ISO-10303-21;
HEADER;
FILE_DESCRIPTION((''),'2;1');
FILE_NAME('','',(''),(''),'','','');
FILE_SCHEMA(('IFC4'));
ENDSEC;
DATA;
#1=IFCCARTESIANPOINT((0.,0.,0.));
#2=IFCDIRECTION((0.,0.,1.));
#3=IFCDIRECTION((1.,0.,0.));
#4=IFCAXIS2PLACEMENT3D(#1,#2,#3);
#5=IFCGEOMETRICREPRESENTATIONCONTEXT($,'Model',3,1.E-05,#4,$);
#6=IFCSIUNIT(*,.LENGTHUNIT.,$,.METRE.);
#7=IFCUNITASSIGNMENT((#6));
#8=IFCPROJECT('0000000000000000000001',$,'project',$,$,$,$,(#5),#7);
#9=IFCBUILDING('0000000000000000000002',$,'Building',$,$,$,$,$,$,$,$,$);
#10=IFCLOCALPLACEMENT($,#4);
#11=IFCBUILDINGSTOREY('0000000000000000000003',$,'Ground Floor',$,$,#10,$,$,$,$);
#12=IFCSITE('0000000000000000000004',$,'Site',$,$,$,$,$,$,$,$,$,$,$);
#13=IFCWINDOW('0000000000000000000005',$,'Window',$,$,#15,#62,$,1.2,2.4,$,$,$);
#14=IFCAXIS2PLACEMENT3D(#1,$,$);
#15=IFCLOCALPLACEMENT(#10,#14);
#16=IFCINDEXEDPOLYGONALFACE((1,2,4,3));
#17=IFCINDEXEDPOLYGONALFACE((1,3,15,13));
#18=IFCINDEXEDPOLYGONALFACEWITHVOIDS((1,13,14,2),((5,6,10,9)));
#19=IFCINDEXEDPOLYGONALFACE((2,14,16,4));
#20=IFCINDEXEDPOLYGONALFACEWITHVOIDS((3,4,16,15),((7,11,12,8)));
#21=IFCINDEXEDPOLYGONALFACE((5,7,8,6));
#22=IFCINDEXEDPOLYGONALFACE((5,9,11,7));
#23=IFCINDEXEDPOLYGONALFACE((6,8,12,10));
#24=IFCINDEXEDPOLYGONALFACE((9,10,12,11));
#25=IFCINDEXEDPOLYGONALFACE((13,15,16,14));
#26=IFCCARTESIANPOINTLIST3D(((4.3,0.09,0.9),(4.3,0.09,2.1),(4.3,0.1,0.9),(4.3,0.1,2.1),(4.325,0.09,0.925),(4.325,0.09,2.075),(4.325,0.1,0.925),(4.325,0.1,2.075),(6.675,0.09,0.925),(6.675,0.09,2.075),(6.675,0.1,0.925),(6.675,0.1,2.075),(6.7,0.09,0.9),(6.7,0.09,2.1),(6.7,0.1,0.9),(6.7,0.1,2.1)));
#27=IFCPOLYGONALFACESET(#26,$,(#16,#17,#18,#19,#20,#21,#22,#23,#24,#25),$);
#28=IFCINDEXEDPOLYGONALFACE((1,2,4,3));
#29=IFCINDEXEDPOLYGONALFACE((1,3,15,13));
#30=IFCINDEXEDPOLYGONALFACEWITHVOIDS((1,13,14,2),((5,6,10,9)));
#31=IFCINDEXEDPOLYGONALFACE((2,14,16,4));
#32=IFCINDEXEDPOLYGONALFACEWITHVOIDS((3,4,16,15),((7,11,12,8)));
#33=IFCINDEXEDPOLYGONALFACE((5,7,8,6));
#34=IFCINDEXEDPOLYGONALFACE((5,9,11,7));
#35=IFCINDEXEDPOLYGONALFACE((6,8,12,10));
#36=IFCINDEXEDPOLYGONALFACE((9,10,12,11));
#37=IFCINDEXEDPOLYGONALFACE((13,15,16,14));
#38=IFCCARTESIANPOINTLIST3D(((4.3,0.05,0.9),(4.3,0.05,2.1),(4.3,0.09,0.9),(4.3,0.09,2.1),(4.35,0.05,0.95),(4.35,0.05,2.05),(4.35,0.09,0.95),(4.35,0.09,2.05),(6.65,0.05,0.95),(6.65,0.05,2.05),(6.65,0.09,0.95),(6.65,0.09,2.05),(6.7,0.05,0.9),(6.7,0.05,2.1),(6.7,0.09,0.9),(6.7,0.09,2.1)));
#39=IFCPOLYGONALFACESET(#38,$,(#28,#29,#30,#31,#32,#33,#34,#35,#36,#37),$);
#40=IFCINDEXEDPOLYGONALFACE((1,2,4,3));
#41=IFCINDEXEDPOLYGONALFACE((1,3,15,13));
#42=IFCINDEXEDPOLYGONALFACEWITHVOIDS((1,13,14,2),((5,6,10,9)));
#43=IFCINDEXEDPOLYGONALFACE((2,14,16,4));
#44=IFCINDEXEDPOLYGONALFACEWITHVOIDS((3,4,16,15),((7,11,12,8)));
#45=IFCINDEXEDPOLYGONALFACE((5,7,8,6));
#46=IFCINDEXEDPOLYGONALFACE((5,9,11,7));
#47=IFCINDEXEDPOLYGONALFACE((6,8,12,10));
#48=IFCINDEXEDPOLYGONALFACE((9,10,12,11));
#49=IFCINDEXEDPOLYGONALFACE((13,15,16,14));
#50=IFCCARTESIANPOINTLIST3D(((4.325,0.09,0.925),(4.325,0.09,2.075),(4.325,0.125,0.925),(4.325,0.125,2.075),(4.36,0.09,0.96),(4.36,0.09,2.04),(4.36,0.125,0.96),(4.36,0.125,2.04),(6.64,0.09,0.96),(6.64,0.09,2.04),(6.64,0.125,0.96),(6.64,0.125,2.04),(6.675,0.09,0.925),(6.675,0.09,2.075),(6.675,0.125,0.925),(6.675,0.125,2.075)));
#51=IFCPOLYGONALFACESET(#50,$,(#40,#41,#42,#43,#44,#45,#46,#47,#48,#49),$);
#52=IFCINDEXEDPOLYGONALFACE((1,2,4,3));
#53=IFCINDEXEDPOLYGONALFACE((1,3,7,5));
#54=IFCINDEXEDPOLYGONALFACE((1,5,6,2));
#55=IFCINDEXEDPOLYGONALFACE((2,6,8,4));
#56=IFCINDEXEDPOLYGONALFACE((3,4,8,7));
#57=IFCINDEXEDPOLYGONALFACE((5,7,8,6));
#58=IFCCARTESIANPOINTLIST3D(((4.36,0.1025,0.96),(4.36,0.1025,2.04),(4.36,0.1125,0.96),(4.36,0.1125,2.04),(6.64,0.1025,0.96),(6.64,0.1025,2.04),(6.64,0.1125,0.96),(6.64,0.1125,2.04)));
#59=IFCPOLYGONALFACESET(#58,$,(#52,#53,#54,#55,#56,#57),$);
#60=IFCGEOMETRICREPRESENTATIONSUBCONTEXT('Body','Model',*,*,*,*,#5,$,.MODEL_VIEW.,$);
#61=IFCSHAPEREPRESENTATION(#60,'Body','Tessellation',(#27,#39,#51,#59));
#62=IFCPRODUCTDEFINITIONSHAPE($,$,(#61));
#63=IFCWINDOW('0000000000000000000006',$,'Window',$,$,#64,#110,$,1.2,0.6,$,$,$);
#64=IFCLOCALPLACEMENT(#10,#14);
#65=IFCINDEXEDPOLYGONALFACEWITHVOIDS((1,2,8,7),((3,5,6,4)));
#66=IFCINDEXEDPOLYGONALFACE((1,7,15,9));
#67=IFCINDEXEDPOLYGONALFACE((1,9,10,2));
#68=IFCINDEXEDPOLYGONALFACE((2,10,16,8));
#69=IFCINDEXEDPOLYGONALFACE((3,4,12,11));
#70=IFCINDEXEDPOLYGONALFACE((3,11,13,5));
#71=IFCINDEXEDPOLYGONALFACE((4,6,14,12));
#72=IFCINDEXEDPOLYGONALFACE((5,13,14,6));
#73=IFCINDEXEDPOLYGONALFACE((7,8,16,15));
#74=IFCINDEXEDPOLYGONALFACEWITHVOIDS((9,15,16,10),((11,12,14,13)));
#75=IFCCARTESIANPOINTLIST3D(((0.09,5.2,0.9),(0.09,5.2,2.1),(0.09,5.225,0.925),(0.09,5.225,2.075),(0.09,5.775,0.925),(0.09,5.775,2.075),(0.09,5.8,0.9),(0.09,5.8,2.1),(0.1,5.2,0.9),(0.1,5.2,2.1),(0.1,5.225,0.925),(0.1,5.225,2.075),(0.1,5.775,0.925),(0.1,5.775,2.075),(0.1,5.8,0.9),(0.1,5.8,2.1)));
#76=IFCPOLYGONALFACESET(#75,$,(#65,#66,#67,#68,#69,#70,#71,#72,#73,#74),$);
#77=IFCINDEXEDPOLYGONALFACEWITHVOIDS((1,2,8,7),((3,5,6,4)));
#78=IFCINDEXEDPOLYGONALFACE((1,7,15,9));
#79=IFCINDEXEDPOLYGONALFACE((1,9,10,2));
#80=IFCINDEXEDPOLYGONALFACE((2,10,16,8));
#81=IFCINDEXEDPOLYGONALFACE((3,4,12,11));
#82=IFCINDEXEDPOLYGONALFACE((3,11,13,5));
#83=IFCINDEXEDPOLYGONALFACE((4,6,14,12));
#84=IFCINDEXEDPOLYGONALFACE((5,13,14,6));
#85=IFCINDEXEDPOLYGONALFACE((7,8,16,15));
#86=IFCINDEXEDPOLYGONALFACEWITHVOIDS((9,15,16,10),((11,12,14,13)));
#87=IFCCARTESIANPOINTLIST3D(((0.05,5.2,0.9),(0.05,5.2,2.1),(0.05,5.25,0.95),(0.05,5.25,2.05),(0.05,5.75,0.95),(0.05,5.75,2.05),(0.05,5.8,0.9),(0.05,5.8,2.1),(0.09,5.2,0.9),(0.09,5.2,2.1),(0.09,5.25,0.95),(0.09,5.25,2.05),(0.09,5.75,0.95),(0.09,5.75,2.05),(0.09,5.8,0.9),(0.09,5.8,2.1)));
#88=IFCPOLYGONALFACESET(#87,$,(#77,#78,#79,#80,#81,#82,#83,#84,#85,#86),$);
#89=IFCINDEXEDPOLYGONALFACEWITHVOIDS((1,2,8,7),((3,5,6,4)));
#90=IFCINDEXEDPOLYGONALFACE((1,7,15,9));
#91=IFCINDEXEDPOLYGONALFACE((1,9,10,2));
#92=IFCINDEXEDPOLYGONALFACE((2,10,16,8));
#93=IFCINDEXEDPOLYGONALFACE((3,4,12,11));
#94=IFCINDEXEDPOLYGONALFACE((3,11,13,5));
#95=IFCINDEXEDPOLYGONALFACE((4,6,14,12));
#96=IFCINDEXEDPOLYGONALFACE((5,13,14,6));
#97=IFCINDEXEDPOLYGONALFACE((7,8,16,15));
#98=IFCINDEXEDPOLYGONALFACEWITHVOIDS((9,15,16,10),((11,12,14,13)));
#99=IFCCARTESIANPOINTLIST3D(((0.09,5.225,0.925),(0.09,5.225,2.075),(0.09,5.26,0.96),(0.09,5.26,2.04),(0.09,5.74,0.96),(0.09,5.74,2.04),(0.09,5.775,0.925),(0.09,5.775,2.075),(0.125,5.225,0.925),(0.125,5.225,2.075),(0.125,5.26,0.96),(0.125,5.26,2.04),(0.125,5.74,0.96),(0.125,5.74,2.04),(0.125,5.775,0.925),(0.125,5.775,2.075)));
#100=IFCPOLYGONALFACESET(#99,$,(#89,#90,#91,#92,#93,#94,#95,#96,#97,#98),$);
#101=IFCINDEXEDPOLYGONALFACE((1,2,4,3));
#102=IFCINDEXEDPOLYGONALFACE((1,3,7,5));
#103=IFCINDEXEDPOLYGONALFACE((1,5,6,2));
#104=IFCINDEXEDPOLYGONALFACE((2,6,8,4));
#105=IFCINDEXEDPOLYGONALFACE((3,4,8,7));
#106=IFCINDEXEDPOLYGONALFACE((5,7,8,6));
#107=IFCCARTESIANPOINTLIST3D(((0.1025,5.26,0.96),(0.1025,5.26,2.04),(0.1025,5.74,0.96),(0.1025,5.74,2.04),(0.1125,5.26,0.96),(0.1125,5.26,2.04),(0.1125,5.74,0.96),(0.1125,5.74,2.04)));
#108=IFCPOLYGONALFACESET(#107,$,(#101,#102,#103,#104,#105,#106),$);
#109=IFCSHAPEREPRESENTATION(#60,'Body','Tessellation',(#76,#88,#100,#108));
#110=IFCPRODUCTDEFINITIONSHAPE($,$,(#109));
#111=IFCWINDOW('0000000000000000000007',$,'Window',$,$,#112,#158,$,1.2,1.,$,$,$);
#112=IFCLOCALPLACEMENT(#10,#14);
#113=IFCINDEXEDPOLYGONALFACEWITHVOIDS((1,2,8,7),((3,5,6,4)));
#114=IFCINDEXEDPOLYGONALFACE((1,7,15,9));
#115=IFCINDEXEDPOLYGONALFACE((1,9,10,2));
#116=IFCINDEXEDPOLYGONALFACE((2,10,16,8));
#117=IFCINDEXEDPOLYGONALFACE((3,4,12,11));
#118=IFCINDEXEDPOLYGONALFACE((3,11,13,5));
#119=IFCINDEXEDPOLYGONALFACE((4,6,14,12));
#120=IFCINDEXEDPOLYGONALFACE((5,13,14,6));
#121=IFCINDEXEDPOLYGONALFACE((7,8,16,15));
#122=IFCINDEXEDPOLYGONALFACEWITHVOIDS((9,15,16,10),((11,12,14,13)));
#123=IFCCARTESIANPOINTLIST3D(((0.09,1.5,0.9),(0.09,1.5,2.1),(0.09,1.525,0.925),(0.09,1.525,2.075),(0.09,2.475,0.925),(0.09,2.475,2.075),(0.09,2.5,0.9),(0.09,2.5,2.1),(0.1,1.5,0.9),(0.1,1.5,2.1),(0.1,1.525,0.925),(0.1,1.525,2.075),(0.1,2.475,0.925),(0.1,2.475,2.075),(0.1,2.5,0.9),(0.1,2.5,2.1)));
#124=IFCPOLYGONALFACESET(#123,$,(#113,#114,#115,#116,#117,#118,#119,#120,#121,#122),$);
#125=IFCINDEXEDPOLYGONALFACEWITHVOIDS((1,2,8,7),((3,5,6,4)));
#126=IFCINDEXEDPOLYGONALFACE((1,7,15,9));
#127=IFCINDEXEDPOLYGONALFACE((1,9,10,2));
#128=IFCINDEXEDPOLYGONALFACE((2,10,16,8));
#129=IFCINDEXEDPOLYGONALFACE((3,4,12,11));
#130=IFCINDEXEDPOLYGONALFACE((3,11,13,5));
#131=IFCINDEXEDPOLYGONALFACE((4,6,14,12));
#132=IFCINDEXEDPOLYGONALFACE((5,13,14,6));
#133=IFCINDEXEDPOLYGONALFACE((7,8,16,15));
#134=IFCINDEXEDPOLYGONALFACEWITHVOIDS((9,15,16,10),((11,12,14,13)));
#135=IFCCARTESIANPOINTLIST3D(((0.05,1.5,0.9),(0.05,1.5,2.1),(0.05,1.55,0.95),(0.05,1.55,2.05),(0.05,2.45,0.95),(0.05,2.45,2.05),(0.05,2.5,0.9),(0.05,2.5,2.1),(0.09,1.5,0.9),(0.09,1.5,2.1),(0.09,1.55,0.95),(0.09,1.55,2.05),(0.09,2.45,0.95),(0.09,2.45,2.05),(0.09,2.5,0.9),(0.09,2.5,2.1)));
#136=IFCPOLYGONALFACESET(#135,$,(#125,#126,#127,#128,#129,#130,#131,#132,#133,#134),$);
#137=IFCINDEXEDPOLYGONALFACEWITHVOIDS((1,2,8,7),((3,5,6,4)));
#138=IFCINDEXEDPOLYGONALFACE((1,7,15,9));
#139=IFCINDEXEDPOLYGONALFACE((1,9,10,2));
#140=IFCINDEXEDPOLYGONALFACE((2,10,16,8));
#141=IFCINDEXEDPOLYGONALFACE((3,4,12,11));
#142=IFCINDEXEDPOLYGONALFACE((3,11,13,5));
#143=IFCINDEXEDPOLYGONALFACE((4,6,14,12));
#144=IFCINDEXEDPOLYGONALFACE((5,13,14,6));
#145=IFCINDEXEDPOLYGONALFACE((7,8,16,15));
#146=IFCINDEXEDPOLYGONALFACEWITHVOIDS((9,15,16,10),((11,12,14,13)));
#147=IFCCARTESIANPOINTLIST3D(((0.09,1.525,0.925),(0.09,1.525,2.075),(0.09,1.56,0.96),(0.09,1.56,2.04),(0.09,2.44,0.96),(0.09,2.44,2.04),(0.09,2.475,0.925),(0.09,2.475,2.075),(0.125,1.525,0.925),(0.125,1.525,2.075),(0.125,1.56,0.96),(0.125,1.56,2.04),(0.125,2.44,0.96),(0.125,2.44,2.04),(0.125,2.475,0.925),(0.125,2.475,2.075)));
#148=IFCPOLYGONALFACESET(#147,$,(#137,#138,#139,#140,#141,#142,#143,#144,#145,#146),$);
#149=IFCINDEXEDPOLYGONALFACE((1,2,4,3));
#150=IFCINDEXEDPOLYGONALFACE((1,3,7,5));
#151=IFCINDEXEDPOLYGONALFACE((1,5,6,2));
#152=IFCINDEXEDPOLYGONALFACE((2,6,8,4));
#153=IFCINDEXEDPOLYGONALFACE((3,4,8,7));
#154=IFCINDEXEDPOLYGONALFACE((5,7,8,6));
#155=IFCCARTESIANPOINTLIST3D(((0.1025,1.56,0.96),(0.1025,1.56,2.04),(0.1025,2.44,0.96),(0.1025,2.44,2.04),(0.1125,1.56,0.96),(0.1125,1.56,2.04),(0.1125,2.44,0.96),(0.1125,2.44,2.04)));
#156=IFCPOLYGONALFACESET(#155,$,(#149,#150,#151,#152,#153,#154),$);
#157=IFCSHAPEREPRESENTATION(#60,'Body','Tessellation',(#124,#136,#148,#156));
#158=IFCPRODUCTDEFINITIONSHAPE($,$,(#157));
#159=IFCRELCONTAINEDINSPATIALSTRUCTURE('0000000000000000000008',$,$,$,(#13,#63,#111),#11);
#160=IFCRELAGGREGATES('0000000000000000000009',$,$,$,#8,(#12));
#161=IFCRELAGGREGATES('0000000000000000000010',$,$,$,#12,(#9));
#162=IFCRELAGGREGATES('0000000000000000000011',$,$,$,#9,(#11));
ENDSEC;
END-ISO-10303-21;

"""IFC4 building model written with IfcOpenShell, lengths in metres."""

from ifc_helpers import new_model, si_unit, frame, origin_with_axes, place, context, subcontext, project, spatial, line, indexed_curve, outline, extrude, element, save


model = new_model("IFC4")

# Units and contexts
model_context = context("Model", 3, precision=1e-05, world=origin_with_axes())
body_context = subcontext(model_context, "Body", "Model", "MODEL_VIEW")
ifc_project = project(units=[si_unit("LENGTHUNIT", "METRE")], contexts=[model_context])

# Site, building, storey
site = spatial("IfcSite", under=ifc_project, Name="Site")
building = spatial("IfcBuilding", under=site, Name="Building")
storey_placement = place(None, origin_with_axes())
storey = spatial("IfcBuildingStorey", under=building, at=storey_placement, Name="Ground Floor")

# Windows
window_1_placement = place(storey_placement, frame((4.3, 0.0, 0.9), z_axis=(0.0, 0.0, 1.0), x_axis=(1.0, 0.0, 0.0)))
element("IfcWindow", 1, at=window_1_placement, inside=storey, Name="Window", OverallHeight=1.2, OverallWidth=2.4, context=body_context, shape_type="SweptSolid", body=[
    extrude(outline(indexed_curve([(0.0, 0.0), (2.4, 0.0), (2.4, 1.2), (0.0, 1.2)], segments=[line(1, 2, 3, 4, 1)]), holes=[indexed_curve([(0.025, 0.025), (2.375, 0.025), (2.375, 1.175), (0.025, 1.175)], segments=[line(1, 2, 3, 4, 1)])]), frame((0.0, 0.09, 0.0), z_axis=(0.0, -1.0, 0.0), x_axis=(1.0, 0.0, 0.0)), (0.0, 0.0, -1.0), 0.01),
    extrude(outline(indexed_curve([(0.0, 0.0), (2.4, 0.0), (2.4, 1.2), (0.0, 1.2)], segments=[line(1, 2, 3, 4, 1)]), holes=[indexed_curve([(0.05, 0.05), (2.35, 0.05), (2.35, 1.15), (0.05, 1.15)], segments=[line(1, 2, 3, 4, 1)])]), frame((0.0, 0.05, 0.0), z_axis=(0.0, -1.0, 0.0), x_axis=(1.0, 0.0, 0.0)), (0.0, 0.0, -1.0), 0.04),
    extrude(outline(indexed_curve([(0.0, 0.0), (2.35, 0.0), (2.35, 1.15), (0.0, 1.15)], segments=[line(1, 2, 3, 4, 1)]), holes=[indexed_curve([(0.035, 0.035), (2.315, 0.035), (2.315, 1.115), (0.035, 1.115)], segments=[line(1, 2, 3, 4, 1)])]), frame((0.025, 0.09, 0.025), z_axis=(0.0, -1.0, 0.0), x_axis=(1.0, 0.0, 0.0)), (0.0, 0.0, -1.0), 0.035),
    extrude(outline(indexed_curve([(0.035, 0.035), (2.315, 0.035), (2.315, 1.115), (0.035, 1.115)], segments=[line(1, 2, 3, 4, 1)])), frame((0.025, 0.1025, 0.025), z_axis=(0.0, -1.0, 0.0), x_axis=(1.0, 0.0, 0.0)), (0.0, 0.0, -1.0), 0.01),
])
window_2_placement = place(storey_placement, frame((0.0, 5.8, 0.9), z_axis=(0.0, 0.0, 1.0), x_axis=(0.0, -1.0, 0.0)))
element("IfcWindow", 2, at=window_2_placement, inside=storey, Name="Window", OverallHeight=1.2, OverallWidth=0.6, context=body_context, shape_type="SweptSolid", body=[
    extrude(outline(indexed_curve([(0.0, 0.0), (0.6, 0.0), (0.6, 1.2), (0.0, 1.2)], segments=[line(1, 2, 3, 4, 1)]), holes=[indexed_curve([(0.025, 0.025), (0.575, 0.025), (0.575, 1.175), (0.025, 1.175)], segments=[line(1, 2, 3, 4, 1)])]), frame((0.0, 0.09, 0.0), z_axis=(0.0, -1.0, 0.0), x_axis=(1.0, 0.0, 0.0)), (0.0, 0.0, -1.0), 0.01),
    extrude(outline(indexed_curve([(0.0, 0.0), (0.6, 0.0), (0.6, 1.2), (0.0, 1.2)], segments=[line(1, 2, 3, 4, 1)]), holes=[indexed_curve([(0.05, 0.05), (0.55, 0.05), (0.55, 1.15), (0.05, 1.15)], segments=[line(1, 2, 3, 4, 1)])]), frame((0.0, 0.05, 0.0), z_axis=(0.0, -1.0, 0.0), x_axis=(1.0, 0.0, 0.0)), (0.0, 0.0, -1.0), 0.04),
    extrude(outline(indexed_curve([(0.0, 0.0), (0.55, 0.0), (0.55, 1.15), (0.0, 1.15)], segments=[line(1, 2, 3, 4, 1)]), holes=[indexed_curve([(0.035, 0.035), (0.515, 0.035), (0.515, 1.115), (0.035, 1.115)], segments=[line(1, 2, 3, 4, 1)])]), frame((0.025, 0.09, 0.025), z_axis=(0.0, -1.0, 0.0), x_axis=(1.0, 0.0, 0.0)), (0.0, 0.0, -1.0), 0.035),
    extrude(outline(indexed_curve([(0.035, 0.035), (0.515, 0.035), (0.515, 1.115), (0.035, 1.115)], segments=[line(1, 2, 3, 4, 1)])), frame((0.025, 0.1025, 0.025), z_axis=(0.0, -1.0, 0.0), x_axis=(1.0, 0.0, 0.0)), (0.0, 0.0, -1.0), 0.01),
])
window_3_placement = place(storey_placement, frame((0.0, 2.5, 0.9), z_axis=(0.0, 0.0, 1.0), x_axis=(0.0, -1.0, 0.0)))
element("IfcWindow", 3, at=window_3_placement, inside=storey, Name="Window", OverallHeight=1.2, OverallWidth=1.0, context=body_context, shape_type="SweptSolid", body=[
    extrude(outline(indexed_curve([(0.0, 0.0), (1.0, 0.0), (1.0, 1.2), (0.0, 1.2)], segments=[line(1, 2, 3, 4, 1)]), holes=[indexed_curve([(0.025, 0.025), (0.975, 0.025), (0.975, 1.175), (0.025, 1.175)], segments=[line(1, 2, 3, 4, 1)])]), frame((0.0, 0.09, 0.0), z_axis=(0.0, -1.0, 0.0), x_axis=(1.0, 0.0, 0.0)), (0.0, 0.0, -1.0), 0.01),
    extrude(outline(indexed_curve([(0.0, 0.0), (1.0, 0.0), (1.0, 1.2), (0.0, 1.2)], segments=[line(1, 2, 3, 4, 1)]), holes=[indexed_curve([(0.05, 0.05), (0.95, 0.05), (0.95, 1.15), (0.05, 1.15)], segments=[line(1, 2, 3, 4, 1)])]), frame((0.0, 0.05, 0.0), z_axis=(0.0, -1.0, 0.0), x_axis=(1.0, 0.0, 0.0)), (0.0, 0.0, -1.0), 0.04),
    extrude(outline(indexed_curve([(0.0, 0.0), (0.95, 0.0), (0.95, 1.15), (0.0, 1.15)], segments=[line(1, 2, 3, 4, 1)]), holes=[indexed_curve([(0.035, 0.035), (0.915, 0.035), (0.915, 1.115), (0.035, 1.115)], segments=[line(1, 2, 3, 4, 1)])]), frame((0.025, 0.09, 0.025), z_axis=(0.0, -1.0, 0.0), x_axis=(1.0, 0.0, 0.0)), (0.0, 0.0, -1.0), 0.035),
    extrude(outline(indexed_curve([(0.035, 0.035), (0.915, 0.035), (0.915, 1.115), (0.035, 1.115)], segments=[line(1, 2, 3, 4, 1)])), frame((0.025, 0.1025, 0.025), z_axis=(0.0, -1.0, 0.0), x_axis=(1.0, 0.0, 0.0)), (0.0, 0.0, -1.0), 0.01),
])

save(model, "model.ifc")
